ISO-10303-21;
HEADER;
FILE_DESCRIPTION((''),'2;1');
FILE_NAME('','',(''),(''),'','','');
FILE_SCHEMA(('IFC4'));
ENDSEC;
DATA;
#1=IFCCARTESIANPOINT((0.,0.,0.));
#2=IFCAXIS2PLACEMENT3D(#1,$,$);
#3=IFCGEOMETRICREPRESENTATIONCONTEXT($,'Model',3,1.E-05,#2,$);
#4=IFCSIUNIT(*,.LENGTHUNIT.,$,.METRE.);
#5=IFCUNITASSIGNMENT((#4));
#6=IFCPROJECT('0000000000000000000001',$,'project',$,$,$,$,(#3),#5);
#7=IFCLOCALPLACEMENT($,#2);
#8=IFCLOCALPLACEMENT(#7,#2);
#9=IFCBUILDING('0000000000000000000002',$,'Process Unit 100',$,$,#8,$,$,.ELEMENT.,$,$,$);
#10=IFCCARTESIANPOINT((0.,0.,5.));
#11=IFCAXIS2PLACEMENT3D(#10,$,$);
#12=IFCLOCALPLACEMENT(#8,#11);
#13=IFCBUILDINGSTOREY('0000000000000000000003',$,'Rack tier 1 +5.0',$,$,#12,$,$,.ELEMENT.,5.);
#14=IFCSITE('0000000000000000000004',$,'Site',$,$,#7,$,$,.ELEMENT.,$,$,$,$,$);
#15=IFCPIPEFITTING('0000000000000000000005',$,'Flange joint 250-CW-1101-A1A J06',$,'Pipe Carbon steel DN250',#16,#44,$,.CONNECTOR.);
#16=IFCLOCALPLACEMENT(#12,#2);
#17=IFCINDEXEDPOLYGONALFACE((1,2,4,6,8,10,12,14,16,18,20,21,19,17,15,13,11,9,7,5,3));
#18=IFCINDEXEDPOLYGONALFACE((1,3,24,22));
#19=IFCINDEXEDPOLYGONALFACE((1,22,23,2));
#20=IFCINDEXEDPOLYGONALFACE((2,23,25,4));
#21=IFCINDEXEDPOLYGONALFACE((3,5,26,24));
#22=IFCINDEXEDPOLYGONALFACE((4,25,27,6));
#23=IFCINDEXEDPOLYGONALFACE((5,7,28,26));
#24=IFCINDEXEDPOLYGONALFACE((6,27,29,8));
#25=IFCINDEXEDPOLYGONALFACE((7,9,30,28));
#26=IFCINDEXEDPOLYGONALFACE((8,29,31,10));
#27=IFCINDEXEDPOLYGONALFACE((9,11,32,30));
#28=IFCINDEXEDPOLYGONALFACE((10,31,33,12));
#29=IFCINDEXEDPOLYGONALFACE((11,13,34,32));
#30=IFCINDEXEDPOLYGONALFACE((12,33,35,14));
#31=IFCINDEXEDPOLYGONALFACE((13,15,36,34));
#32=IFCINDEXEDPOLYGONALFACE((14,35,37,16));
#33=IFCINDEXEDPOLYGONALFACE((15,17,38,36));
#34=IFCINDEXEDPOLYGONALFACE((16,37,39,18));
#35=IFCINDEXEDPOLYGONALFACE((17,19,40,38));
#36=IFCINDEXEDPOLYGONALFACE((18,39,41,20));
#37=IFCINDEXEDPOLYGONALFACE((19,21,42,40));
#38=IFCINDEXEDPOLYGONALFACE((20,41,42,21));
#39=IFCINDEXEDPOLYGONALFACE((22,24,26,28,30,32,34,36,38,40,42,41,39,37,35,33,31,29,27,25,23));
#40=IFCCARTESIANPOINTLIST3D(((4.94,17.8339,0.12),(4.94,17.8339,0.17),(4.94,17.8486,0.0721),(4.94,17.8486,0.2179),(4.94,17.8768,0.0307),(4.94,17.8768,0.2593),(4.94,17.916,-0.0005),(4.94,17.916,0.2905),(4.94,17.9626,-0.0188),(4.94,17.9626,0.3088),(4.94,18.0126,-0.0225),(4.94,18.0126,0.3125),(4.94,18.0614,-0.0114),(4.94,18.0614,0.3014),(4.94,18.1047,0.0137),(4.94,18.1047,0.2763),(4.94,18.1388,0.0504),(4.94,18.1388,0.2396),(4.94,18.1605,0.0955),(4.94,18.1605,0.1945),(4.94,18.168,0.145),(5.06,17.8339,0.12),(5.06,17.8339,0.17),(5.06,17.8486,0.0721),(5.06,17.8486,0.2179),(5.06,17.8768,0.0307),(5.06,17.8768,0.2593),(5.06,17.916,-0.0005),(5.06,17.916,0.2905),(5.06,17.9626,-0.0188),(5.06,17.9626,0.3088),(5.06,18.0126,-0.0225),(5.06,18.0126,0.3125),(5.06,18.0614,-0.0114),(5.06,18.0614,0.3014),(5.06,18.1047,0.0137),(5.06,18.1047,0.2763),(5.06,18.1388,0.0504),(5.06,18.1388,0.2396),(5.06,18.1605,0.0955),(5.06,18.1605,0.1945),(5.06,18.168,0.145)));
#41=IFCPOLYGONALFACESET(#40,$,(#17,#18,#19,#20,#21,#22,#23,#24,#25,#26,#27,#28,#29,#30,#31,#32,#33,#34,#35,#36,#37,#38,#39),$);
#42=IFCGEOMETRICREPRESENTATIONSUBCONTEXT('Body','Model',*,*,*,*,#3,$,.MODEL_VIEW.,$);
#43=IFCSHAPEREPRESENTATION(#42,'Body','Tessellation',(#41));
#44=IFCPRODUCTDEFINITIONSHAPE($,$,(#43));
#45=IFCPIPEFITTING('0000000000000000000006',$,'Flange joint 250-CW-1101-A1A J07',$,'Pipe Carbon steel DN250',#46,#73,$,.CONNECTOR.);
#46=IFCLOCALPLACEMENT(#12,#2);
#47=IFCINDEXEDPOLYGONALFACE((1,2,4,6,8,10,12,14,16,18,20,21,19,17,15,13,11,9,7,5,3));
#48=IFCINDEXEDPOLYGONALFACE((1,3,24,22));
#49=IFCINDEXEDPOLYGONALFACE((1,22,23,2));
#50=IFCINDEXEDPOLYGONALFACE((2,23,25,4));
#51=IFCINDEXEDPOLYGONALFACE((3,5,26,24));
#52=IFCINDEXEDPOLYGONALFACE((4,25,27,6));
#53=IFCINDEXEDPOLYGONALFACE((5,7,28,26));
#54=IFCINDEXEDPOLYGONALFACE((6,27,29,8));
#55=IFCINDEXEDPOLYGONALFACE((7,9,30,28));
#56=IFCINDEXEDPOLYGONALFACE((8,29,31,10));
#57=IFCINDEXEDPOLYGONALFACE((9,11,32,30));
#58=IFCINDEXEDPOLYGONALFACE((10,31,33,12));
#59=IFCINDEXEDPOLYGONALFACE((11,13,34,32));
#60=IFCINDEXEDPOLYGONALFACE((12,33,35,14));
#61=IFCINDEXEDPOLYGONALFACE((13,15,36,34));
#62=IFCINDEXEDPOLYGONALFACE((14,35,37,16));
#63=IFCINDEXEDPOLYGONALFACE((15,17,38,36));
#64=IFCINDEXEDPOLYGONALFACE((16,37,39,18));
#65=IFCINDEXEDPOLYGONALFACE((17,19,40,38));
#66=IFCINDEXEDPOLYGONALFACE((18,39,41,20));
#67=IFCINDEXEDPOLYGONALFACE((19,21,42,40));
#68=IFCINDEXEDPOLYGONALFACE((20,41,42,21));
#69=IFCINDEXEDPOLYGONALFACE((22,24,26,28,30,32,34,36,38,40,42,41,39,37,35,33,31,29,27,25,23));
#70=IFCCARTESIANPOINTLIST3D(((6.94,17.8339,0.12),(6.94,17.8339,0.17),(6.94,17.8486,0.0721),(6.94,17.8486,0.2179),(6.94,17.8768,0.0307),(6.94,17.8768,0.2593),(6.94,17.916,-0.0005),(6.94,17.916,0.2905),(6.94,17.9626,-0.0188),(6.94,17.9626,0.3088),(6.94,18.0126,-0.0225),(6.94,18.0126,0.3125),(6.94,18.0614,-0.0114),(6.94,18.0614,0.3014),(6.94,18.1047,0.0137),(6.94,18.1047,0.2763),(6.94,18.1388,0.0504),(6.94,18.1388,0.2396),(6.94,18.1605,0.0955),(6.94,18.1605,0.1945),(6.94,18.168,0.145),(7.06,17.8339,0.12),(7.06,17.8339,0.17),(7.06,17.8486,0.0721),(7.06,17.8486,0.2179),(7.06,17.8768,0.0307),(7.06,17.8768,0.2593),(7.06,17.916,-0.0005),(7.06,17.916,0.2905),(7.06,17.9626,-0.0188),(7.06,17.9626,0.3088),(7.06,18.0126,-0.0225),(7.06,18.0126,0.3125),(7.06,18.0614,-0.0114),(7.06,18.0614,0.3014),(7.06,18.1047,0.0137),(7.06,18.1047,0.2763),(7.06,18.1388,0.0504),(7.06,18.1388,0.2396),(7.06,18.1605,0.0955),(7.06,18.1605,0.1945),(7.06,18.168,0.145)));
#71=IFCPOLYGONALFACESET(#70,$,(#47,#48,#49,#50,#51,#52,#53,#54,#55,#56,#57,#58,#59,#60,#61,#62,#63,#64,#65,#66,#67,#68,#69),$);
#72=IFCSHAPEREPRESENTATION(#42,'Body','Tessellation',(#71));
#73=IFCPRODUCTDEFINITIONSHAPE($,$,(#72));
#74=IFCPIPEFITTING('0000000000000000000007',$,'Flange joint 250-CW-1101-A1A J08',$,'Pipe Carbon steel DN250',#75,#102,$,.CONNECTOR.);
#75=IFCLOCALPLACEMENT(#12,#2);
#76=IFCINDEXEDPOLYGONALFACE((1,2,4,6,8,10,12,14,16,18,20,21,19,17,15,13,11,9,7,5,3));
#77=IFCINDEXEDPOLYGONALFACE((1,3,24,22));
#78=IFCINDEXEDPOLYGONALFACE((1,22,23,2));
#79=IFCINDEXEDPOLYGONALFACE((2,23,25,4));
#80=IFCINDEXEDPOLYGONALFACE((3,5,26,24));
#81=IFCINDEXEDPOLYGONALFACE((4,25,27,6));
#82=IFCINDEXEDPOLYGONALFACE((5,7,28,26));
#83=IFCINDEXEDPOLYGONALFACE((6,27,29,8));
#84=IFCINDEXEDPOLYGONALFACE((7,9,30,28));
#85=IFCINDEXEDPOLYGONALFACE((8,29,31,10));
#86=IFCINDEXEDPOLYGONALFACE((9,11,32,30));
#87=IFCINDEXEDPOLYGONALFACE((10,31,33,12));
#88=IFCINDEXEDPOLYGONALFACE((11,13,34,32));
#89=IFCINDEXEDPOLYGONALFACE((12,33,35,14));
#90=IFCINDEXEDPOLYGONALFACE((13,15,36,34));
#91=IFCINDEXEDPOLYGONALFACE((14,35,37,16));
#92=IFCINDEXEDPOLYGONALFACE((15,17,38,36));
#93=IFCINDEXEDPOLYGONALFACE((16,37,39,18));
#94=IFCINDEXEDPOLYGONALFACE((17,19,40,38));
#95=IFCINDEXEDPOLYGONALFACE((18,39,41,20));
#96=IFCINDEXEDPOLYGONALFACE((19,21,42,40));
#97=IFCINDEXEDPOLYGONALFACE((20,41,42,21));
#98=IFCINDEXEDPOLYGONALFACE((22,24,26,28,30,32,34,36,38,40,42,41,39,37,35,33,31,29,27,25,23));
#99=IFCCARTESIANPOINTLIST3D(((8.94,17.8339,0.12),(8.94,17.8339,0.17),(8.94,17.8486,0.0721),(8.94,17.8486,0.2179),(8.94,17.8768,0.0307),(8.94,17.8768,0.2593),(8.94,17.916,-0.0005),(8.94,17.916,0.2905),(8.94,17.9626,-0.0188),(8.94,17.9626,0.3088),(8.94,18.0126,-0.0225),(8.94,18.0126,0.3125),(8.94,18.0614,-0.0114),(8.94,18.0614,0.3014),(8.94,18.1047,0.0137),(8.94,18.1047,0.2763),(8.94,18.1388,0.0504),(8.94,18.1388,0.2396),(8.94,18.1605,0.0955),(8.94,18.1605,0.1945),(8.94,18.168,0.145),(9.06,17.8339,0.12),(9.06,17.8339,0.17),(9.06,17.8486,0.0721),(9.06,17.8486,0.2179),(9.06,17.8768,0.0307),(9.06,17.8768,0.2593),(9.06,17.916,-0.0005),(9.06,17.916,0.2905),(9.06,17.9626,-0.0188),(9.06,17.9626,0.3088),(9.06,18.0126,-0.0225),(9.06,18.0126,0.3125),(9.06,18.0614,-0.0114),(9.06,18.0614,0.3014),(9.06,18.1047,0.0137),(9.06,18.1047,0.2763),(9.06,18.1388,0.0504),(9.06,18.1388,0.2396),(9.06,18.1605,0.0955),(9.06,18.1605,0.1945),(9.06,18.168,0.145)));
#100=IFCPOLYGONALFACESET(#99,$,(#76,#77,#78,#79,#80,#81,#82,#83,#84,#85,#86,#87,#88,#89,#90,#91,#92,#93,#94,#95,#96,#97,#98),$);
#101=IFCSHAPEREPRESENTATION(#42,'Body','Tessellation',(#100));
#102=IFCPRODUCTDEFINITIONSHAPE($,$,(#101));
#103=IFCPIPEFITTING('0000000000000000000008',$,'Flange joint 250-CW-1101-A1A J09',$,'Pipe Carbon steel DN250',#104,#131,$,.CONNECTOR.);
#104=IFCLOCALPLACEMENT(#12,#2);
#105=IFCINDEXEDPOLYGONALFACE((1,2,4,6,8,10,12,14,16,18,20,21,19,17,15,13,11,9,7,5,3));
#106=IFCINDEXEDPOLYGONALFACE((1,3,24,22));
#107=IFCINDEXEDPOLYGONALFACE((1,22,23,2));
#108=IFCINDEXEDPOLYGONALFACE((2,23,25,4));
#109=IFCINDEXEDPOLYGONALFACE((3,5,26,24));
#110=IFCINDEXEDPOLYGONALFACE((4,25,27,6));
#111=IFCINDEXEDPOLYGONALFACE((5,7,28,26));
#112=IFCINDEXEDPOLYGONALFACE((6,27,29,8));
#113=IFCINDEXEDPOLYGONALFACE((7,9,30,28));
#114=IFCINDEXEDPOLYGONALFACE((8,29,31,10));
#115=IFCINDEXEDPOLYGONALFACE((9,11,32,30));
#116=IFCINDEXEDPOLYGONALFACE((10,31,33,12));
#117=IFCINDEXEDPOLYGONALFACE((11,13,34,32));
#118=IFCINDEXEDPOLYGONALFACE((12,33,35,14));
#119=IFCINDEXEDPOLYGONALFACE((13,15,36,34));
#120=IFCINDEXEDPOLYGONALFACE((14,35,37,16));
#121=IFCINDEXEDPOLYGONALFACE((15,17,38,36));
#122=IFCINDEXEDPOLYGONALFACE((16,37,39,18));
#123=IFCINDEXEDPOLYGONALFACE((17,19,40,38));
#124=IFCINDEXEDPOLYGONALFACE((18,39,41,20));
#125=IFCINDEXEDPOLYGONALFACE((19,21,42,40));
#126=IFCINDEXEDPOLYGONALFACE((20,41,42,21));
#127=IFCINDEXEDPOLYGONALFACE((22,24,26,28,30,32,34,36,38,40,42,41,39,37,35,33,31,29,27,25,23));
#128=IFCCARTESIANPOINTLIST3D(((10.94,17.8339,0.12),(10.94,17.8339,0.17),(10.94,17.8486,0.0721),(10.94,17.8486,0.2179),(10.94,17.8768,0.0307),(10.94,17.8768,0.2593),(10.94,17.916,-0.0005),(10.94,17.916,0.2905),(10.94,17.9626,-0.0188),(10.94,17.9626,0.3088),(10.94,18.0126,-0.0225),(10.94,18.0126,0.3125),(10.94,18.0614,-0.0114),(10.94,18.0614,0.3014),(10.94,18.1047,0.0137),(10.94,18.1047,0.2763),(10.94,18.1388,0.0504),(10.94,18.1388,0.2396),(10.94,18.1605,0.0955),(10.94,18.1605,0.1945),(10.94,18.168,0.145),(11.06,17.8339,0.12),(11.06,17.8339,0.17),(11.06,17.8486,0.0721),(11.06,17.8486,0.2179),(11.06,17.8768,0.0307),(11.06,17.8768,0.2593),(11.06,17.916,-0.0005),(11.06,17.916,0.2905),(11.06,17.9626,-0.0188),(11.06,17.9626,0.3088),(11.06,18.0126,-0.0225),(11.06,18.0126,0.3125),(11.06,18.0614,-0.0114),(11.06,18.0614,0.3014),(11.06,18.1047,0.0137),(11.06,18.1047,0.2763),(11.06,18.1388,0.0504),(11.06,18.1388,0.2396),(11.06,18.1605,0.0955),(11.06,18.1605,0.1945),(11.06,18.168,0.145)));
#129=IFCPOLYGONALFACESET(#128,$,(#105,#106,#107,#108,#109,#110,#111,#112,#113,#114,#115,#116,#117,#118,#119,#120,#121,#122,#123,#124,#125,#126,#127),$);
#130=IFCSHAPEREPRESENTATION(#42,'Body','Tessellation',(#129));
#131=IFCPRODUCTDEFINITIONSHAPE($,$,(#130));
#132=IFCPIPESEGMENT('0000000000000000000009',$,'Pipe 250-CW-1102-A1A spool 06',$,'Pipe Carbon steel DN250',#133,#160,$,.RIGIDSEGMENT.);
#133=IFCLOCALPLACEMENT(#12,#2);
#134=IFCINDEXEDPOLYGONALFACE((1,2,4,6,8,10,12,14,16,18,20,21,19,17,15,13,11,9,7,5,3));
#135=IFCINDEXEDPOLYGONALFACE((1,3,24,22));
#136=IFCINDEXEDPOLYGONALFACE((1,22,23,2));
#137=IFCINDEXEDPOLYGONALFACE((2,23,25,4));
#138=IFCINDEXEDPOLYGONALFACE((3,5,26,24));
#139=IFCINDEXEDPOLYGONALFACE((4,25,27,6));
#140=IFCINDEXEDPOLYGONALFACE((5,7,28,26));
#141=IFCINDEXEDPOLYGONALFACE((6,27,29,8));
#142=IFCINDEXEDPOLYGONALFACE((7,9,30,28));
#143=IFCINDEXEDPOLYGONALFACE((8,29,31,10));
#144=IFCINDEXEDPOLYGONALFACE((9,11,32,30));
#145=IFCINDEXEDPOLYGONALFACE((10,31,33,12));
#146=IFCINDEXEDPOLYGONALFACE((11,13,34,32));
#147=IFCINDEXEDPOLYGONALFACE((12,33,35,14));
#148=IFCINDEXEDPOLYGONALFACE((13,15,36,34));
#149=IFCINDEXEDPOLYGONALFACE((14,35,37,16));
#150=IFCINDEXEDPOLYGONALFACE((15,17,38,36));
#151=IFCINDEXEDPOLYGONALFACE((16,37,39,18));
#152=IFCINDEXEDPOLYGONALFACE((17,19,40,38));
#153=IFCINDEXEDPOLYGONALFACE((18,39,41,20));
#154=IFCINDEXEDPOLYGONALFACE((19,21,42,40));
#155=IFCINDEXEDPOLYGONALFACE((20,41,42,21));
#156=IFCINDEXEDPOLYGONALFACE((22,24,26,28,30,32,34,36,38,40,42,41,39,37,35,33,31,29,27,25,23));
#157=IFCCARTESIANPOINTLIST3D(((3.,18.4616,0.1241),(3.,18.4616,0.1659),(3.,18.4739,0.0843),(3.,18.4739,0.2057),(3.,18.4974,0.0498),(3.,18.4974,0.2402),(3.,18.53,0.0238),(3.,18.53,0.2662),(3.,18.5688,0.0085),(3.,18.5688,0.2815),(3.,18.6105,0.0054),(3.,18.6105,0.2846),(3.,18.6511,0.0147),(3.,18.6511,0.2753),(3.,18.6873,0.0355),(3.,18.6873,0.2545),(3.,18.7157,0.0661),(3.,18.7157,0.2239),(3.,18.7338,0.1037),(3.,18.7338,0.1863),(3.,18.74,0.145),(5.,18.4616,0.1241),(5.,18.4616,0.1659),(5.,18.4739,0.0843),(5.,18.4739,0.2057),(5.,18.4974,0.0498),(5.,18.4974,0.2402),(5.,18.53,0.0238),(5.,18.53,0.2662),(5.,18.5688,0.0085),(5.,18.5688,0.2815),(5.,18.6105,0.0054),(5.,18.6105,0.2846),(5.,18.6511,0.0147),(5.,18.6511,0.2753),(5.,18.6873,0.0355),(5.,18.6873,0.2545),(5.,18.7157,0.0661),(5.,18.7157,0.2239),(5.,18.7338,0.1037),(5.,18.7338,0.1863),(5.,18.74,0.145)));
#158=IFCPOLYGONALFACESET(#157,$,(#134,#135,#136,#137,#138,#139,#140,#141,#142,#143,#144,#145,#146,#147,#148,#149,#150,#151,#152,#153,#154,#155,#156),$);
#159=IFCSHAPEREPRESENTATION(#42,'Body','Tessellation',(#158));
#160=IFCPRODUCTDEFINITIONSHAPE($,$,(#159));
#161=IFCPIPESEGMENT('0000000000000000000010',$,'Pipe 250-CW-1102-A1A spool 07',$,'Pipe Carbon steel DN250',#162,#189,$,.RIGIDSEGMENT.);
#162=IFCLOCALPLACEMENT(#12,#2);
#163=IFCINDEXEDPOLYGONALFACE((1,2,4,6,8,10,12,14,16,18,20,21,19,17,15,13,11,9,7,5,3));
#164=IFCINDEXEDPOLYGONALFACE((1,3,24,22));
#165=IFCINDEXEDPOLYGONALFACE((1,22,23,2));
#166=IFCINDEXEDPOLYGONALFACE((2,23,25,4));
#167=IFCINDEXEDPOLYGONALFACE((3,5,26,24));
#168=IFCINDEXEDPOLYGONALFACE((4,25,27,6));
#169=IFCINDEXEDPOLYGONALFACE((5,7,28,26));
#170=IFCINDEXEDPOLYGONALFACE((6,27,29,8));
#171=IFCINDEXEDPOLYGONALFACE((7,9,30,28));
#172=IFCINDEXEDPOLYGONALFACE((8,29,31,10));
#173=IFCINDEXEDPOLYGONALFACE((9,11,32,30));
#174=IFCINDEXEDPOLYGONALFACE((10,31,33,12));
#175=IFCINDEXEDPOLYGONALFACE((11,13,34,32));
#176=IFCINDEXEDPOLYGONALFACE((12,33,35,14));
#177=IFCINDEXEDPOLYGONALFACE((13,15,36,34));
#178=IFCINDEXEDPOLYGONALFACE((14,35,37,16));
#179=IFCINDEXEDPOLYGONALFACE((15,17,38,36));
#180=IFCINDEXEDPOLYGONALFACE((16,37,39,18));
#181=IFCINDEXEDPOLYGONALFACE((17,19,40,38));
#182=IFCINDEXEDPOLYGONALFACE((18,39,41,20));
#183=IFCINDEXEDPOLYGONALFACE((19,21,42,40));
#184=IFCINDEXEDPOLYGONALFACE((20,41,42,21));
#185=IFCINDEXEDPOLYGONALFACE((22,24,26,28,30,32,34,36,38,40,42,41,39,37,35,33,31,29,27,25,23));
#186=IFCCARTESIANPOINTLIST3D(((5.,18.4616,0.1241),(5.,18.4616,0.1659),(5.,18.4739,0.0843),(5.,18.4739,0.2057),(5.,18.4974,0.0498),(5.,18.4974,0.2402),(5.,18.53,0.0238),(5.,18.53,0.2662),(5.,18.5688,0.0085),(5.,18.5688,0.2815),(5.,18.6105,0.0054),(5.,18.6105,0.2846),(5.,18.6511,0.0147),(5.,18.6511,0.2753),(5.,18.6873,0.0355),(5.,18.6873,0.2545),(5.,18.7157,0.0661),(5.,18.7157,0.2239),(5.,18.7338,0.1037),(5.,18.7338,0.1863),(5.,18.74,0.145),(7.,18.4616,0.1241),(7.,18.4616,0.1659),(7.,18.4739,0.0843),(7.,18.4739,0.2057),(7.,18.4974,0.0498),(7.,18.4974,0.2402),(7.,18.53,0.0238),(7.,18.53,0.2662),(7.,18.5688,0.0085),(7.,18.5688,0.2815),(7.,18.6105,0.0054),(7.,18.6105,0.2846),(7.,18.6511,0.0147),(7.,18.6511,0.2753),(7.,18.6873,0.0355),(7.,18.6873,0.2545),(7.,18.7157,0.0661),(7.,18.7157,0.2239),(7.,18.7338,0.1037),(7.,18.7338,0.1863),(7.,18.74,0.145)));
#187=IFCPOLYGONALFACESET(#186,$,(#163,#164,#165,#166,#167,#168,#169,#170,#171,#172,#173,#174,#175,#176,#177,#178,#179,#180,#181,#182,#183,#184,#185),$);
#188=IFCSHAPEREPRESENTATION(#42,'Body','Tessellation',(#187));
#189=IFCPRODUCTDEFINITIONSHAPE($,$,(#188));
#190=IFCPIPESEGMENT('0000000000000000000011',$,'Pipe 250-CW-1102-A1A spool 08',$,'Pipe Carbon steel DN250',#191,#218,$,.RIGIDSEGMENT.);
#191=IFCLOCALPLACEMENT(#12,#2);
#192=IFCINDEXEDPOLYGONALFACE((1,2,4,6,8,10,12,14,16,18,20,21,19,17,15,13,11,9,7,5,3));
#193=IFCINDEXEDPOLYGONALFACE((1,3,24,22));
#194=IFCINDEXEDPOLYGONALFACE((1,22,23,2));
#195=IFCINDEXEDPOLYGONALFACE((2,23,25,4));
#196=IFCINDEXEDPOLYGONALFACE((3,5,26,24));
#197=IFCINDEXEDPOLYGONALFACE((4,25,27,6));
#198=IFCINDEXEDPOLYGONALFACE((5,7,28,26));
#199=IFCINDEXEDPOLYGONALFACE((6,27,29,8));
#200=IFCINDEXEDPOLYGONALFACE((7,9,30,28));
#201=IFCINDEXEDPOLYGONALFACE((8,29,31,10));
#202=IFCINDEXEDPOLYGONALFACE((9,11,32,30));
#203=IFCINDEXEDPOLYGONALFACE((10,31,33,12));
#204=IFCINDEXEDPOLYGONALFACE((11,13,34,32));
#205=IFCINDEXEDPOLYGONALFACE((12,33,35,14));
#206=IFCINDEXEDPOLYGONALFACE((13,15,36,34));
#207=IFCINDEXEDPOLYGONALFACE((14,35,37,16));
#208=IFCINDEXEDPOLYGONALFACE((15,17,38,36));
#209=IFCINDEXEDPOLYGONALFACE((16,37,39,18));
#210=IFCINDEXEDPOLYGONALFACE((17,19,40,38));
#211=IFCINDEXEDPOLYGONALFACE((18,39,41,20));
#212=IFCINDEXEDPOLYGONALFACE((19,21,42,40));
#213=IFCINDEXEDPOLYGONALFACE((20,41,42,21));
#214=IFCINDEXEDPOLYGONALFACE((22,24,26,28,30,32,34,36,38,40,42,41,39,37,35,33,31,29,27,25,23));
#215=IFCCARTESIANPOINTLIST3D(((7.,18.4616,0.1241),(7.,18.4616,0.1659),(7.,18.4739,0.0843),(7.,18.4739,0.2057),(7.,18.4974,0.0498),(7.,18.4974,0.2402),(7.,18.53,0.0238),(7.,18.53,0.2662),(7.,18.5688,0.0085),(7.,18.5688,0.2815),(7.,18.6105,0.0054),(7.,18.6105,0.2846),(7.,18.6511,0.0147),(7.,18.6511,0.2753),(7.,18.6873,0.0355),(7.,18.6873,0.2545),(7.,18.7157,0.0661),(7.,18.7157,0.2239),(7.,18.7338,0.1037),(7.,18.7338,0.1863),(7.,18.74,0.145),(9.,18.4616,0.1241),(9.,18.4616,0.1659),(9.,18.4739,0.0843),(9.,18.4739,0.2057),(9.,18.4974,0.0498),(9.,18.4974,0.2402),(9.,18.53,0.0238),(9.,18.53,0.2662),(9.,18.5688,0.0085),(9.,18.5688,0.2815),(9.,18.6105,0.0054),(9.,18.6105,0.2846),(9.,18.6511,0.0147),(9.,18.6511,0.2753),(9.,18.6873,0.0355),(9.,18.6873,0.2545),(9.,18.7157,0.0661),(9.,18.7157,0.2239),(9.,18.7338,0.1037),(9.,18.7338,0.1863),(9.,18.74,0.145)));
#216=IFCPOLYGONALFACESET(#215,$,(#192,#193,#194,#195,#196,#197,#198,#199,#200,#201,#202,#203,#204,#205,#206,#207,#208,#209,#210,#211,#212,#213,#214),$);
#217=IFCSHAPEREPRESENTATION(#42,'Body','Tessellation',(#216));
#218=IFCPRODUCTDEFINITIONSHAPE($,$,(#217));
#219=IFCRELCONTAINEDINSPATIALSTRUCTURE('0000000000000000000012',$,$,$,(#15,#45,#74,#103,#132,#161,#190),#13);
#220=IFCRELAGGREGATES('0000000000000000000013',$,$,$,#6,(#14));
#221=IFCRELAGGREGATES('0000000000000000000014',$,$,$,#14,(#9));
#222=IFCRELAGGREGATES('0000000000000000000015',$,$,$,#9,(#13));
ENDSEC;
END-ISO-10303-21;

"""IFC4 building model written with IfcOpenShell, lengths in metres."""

from ifc_helpers import new_model, si_unit, frame, origin, place, context, subcontext, project, spatial, circle, extrude, element, save


model = new_model("IFC4")

# Units and contexts
model_context = context("Model", 3, precision=1e-05, world=origin())
body_context = subcontext(model_context, "Body", "Model", "MODEL_VIEW")
ifc_project = project(units=[si_unit("LENGTHUNIT", "METRE")], contexts=[model_context])

# Site, building, storey
site_placement = place(None, origin())
site = spatial("IfcSite", under=ifc_project, at=site_placement, Name="Site", CompositionType="ELEMENT")
building_placement = place(site_placement, origin())
building = spatial("IfcBuilding", under=site, at=building_placement, Name="Process Unit 100", CompositionType="ELEMENT")
storey_placement = place(building_placement, frame((0.0, 0.0, 5.0)))
storey = spatial("IfcBuildingStorey", under=building, at=storey_placement, Name="Rack tier 1 +5.0", CompositionType="ELEMENT", Elevation=5.0)

# Pipe fittings
for number, where, z_axis, x_axis, name in (
    (1, (4.94, 18.0, 0.145), (1.0, 0.0, 0.0), (0.0, 1.0, 0.0), "Flange joint 250-CW-1101-A1A J06"),
    (2, (6.94, 18.0, 0.145), (1.0, 0.0, 0.0), (0.0, 1.0, 0.0), "Flange joint 250-CW-1101-A1A J07"),
    (3, (8.94, 18.0, 0.145), (1.0, 0.0, 0.0), (0.0, 1.0, 0.0), "Flange joint 250-CW-1101-A1A J08"),
    (4, (10.94, 18.0, 0.145), (1.0, 0.0, 0.0), (0.0, 1.0, 0.0), "Flange joint 250-CW-1101-A1A J09"),
):
    element("IfcPipeFitting", number, at=place(storey_placement, frame(where, z_axis=z_axis, x_axis=x_axis)), inside=storey, Name=name, ObjectType="Pipe Carbon steel DN250", PredefinedType="CONNECTOR", context=body_context, shape_type="SweptSolid", body=[
        extrude(circle(Radius=0.168), origin(), (0.0, 0.0, 1.0), 0.12),
    ])

# Pipe segments
for number, where, z_axis, x_axis, name in (
    (5, (3.0, 18.6, 0.145), (1.0, 0.0, 0.0), (0.0, 1.0, 0.0), "Pipe 250-CW-1102-A1A spool 06"),
    (6, (5.0, 18.6, 0.145), (1.0, 0.0, 0.0), (0.0, 1.0, 0.0), "Pipe 250-CW-1102-A1A spool 07"),
    (7, (7.0, 18.6, 0.145), (1.0, 0.0, 0.0), (0.0, 1.0, 0.0), "Pipe 250-CW-1102-A1A spool 08"),
):
    element("IfcPipeSegment", number, at=place(storey_placement, frame(where, z_axis=z_axis, x_axis=x_axis)), inside=storey, Name=name, ObjectType="Pipe Carbon steel DN250", PredefinedType="RIGIDSEGMENT", context=body_context, shape_type="SweptSolid", body=[
        extrude(circle(Radius=0.14), origin(), (0.0, 0.0, 1.0), 2.0),
    ])

save(model, "model.ifc")
